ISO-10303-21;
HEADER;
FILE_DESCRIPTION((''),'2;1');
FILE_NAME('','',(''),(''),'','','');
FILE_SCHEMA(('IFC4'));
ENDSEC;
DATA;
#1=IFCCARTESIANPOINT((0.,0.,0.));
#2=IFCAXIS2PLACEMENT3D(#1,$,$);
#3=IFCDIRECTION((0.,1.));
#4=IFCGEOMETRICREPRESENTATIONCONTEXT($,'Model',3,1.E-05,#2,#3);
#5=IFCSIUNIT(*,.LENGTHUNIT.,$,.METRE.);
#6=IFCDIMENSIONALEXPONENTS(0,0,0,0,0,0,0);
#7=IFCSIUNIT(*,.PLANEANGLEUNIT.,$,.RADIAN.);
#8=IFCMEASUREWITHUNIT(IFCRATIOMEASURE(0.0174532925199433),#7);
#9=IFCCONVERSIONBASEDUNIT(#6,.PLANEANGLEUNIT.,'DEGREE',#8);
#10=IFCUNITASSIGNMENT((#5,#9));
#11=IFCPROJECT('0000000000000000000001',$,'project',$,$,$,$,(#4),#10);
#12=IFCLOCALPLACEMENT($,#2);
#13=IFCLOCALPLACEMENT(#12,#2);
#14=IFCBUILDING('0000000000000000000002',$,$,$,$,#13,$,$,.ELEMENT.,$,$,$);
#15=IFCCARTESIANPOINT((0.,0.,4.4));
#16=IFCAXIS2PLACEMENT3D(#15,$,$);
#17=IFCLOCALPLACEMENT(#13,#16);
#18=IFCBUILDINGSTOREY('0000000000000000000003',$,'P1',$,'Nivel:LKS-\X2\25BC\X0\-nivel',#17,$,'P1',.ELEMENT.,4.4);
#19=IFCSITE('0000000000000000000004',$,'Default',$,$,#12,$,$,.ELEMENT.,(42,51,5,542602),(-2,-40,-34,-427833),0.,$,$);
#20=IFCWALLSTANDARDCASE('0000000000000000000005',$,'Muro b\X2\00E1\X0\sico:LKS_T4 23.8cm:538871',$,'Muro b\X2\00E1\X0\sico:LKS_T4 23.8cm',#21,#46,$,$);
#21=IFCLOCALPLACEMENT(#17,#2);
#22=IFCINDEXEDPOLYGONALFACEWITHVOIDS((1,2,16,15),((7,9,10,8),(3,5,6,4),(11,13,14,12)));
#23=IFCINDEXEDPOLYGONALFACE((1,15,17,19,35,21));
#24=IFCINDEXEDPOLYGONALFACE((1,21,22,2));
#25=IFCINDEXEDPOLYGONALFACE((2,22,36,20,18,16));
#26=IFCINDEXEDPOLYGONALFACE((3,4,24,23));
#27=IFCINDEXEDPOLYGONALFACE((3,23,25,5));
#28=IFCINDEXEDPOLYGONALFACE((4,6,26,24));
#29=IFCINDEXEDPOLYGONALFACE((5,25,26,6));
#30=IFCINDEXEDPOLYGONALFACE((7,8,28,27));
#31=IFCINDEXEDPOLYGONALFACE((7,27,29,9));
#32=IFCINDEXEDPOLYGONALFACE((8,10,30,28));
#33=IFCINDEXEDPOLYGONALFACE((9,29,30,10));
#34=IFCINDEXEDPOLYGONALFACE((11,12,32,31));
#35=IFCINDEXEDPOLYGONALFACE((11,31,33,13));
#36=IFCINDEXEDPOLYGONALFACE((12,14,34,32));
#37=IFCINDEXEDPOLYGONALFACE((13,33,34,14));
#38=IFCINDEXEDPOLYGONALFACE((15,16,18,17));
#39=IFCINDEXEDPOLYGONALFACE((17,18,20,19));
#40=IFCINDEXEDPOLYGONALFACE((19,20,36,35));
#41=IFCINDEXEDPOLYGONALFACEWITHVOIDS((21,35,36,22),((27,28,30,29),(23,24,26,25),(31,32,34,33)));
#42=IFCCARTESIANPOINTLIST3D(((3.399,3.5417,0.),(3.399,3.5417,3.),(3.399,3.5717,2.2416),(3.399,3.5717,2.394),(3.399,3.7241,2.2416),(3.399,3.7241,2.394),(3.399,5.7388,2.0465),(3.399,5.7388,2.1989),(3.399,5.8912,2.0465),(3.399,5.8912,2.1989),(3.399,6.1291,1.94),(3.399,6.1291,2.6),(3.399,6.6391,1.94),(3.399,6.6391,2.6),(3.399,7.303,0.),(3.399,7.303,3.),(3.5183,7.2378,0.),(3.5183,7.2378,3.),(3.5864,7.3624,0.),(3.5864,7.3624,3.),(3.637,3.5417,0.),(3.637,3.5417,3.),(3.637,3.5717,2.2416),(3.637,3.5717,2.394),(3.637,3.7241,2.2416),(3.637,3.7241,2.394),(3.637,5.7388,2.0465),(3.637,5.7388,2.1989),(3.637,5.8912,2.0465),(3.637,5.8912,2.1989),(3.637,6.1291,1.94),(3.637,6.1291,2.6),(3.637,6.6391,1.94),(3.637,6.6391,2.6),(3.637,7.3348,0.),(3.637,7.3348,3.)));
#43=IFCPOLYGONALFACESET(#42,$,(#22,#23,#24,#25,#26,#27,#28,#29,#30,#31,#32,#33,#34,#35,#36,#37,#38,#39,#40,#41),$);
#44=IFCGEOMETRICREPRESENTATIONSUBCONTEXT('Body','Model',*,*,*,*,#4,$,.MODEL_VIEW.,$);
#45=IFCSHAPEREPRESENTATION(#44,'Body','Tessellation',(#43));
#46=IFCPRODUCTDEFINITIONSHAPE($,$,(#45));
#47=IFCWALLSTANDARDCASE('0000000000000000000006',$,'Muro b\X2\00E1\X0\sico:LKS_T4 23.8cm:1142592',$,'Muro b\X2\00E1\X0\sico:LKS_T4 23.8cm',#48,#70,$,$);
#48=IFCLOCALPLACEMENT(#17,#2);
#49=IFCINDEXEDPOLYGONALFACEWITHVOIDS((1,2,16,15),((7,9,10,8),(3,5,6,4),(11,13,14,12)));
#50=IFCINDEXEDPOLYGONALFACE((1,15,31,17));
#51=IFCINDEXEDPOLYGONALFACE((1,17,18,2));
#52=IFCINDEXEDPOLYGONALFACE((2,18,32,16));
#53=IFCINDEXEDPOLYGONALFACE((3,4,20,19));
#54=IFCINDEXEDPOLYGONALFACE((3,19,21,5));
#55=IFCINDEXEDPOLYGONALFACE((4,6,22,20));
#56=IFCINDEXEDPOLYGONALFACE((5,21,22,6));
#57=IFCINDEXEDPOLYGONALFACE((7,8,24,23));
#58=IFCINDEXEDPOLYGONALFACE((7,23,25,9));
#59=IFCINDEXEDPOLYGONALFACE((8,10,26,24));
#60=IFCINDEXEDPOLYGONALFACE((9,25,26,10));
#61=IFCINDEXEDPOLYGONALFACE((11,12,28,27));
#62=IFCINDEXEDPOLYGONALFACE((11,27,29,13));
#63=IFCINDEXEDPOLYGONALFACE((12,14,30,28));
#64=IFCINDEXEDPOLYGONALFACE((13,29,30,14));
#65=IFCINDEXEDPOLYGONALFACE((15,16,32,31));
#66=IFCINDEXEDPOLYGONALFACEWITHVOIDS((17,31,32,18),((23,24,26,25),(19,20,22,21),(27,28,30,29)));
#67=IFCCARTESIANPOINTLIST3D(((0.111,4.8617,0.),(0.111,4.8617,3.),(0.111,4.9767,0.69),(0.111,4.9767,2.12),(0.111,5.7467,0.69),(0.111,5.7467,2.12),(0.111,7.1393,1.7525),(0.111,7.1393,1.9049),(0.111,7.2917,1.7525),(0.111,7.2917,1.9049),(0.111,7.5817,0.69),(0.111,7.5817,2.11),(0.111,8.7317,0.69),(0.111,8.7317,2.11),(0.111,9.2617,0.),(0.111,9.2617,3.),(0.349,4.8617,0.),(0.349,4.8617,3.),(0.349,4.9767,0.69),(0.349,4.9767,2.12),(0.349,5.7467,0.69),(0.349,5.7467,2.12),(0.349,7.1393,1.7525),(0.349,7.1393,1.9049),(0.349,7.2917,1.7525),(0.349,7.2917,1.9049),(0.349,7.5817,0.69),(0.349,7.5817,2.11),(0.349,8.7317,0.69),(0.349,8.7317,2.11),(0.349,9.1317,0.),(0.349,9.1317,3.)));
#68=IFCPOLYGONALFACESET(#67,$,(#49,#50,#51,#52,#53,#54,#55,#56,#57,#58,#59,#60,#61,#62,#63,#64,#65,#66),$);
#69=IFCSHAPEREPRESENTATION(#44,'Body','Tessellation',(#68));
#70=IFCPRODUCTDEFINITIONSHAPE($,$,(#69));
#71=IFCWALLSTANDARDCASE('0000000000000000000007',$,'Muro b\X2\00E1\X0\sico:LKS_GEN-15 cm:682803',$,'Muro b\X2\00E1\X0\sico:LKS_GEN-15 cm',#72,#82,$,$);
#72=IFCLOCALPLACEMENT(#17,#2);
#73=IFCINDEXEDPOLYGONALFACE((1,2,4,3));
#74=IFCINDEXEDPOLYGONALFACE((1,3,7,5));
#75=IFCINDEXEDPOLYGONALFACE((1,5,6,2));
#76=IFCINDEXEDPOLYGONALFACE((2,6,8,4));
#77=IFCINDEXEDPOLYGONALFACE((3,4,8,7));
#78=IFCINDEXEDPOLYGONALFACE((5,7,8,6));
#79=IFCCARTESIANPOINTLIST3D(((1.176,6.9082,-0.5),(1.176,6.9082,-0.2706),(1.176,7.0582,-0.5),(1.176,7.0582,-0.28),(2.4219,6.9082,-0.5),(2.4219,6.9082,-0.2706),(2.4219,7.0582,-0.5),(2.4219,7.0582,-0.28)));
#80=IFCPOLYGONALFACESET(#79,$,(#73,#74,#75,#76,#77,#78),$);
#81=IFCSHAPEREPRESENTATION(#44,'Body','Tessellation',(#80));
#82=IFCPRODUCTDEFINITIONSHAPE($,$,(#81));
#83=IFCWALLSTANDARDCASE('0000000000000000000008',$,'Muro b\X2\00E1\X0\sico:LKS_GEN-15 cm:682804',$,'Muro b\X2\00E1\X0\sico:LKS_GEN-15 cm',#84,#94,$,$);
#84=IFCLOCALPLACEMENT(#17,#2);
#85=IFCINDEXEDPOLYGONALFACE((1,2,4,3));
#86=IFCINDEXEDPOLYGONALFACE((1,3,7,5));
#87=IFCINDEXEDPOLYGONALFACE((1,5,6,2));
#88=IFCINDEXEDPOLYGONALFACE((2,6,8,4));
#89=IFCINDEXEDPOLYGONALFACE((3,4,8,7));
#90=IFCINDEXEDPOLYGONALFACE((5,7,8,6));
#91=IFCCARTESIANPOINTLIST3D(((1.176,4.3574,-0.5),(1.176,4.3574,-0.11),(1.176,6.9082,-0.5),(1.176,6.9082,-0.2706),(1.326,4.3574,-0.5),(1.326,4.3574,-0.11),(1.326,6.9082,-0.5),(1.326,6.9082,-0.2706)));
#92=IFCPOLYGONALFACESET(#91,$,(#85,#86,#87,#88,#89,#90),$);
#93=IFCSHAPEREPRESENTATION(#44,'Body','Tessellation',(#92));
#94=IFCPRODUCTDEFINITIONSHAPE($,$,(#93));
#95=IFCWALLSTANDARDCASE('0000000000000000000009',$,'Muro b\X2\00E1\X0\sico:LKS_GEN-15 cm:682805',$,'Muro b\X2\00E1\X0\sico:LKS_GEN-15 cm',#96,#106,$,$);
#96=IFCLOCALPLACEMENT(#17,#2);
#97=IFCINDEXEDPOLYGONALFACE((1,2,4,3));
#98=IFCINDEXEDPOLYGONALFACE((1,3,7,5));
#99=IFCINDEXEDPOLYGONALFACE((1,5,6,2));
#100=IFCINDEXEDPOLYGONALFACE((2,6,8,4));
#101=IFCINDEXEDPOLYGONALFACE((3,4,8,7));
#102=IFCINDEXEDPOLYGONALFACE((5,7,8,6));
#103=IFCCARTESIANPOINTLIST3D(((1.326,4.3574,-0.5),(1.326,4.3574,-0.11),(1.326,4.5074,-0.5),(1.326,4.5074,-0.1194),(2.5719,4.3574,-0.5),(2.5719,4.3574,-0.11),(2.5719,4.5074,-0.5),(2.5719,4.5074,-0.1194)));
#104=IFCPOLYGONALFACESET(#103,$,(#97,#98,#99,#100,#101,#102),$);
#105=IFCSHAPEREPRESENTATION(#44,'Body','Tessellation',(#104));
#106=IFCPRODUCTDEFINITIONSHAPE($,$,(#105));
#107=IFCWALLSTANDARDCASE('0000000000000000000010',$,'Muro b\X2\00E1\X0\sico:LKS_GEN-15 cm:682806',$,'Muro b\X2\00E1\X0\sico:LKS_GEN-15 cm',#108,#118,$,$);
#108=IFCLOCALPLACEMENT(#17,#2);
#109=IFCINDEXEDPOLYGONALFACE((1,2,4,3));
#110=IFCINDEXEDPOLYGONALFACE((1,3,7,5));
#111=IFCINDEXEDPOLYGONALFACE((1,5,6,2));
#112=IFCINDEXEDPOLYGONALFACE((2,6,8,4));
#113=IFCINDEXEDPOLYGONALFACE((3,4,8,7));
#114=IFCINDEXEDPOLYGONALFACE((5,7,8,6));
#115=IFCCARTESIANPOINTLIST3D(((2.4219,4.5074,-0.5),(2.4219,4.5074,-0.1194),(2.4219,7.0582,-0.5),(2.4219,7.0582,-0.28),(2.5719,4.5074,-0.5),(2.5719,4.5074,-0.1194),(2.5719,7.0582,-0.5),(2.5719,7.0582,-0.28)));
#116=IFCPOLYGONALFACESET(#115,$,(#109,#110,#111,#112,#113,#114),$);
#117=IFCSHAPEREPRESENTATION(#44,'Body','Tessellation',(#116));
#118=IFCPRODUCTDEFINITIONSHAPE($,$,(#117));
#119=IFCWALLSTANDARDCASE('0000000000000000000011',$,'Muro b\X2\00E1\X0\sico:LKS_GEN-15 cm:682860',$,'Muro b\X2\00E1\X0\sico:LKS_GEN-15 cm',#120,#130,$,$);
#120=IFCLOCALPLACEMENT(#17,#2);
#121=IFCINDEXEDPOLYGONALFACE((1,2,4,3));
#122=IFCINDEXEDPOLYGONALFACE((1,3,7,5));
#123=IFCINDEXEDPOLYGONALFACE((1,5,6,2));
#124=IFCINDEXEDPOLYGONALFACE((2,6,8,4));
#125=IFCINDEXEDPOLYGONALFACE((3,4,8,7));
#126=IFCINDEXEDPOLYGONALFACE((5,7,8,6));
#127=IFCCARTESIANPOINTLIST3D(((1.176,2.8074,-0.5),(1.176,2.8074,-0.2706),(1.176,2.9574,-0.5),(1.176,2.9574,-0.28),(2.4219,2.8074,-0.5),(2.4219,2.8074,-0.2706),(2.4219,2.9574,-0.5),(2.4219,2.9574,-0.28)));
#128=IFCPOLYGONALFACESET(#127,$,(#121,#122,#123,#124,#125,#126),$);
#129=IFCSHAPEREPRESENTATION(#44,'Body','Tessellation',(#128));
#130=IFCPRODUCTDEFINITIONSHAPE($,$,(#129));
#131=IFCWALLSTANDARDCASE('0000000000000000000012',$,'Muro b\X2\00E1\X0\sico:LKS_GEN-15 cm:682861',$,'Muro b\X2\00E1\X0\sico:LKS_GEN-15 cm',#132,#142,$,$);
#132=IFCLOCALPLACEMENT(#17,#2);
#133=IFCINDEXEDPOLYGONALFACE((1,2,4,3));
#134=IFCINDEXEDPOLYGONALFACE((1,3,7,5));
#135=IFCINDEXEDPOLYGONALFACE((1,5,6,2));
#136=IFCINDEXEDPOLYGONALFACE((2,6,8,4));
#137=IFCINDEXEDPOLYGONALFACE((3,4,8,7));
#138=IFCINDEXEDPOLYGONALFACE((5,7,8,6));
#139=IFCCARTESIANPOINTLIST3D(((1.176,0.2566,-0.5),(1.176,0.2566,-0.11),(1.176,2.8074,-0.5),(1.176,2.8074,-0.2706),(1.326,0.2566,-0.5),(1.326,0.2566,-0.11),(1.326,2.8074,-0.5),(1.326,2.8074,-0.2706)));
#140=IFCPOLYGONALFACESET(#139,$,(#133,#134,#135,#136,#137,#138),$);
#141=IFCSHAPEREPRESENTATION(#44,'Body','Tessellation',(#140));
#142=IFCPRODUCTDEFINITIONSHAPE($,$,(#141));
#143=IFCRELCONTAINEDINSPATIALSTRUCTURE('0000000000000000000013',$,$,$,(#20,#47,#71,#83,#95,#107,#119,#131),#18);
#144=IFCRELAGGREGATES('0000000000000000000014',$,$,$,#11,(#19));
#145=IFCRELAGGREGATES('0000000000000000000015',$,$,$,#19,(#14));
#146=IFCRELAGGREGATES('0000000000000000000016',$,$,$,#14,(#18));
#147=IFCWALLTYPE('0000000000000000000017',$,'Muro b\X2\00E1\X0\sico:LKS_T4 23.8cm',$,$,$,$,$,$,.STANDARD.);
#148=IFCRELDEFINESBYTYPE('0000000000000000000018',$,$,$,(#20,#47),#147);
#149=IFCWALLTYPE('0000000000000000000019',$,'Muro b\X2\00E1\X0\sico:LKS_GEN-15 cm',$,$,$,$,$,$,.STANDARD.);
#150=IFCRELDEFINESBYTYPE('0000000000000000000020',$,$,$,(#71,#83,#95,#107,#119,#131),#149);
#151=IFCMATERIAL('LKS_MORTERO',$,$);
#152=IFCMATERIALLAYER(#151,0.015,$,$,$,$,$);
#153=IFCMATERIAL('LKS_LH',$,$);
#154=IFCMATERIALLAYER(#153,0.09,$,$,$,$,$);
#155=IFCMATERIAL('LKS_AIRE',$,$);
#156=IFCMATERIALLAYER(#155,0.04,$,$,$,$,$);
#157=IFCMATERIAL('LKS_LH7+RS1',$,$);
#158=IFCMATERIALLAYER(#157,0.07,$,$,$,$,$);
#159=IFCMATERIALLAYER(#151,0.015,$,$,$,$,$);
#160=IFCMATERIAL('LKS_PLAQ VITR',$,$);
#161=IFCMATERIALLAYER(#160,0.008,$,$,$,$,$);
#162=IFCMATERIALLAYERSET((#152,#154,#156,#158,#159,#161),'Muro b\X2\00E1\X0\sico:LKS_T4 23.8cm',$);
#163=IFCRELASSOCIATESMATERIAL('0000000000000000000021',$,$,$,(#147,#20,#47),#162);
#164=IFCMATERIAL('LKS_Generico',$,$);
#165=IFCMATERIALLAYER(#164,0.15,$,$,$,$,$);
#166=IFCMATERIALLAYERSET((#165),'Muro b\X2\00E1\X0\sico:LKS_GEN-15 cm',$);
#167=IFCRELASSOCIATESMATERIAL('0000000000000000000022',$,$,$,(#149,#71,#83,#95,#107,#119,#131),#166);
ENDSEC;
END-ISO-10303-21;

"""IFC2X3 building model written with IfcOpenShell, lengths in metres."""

from ifc_helpers import new_model, entity, si_unit, converted_unit, direction, frame, frame_2d, origin, place, context, subcontext, project, spatial, polyline, rectangle, outline, extrude, clip, bounded_halfspace, material, layer, layer_set, layer_usage, type_object, element, save


model = new_model("IFC2X3")

# Units and contexts
model_context = context("Model", 3, precision=1e-05, world=origin(), true_north=direction((0.0, 1.0)))
body_context = subcontext(model_context, "Body", "Model", "MODEL_VIEW")
ifc_project = project(units=[si_unit("LENGTHUNIT", "METRE"), converted_unit("PLANEANGLEUNIT", "DEGREE", entity("IfcRatioMeasure", 0.0174532925199433), si_unit("PLANEANGLEUNIT", "RADIAN"), dimensions=[0, 0, 0, 0, 0, 0, 0])], contexts=[model_context])

# Site, building, storey
site_placement = place(None, origin())
site = spatial("IfcSite", under=ifc_project, at=site_placement, Name="Default", CompositionType="ELEMENT", RefLatitude=(42, 51, 5, 542602), RefLongitude=(-2, -40, -34, -427833), RefElevation=0.0)
building_placement = place(site_placement, origin())
building = spatial("IfcBuilding", under=site, at=building_placement, CompositionType="ELEMENT")
storey_placement = place(building_placement, frame((0.0, 0.0, 4.4)))
storey = spatial("IfcBuildingStorey", under=building, at=storey_placement, Name="P1", ObjectType="Nivel:LKS-▼-nivel", LongName="P1", CompositionType="ELEMENT", Elevation=4.4)

# Shared definitions
ifc_material_1 = material(Name="LKS_Generico")

# Shared definitions
ifc_material_2 = material(Name="LKS_MORTERO")
ifc_material_3 = material(Name="LKS_PLAQ VITR")

# Shared definitions
ifc_material_4 = material(Name="LKS_LH")
ifc_material_5 = material(Name="LKS_AIRE")
ifc_material_6 = material(Name="LKS_LH7+RS1")

# Walls, openings
ifc_layer_1 = layer(ifc_material_2, 0.015)
ifc_layer_2 = layer(ifc_material_4, 0.09)
ifc_layer_3 = layer(ifc_material_5, 0.04)
ifc_layer_4 = layer(ifc_material_6, 0.07)
ifc_layer_5 = layer(ifc_material_2, 0.015)
ifc_layer_6 = layer(ifc_material_3, 0.008)
ifc_layer_set_1 = layer_set([ifc_layer_1, ifc_layer_2, ifc_layer_3, ifc_layer_4, ifc_layer_5, ifc_layer_6], Name="Muro básico:LKS_T4 23.8cm")
ifc_layer_usage_1 = layer_usage(ifc_layer_set_1, "AXIS2", "POSITIVE", -0.119)
wall_type_1 = type_object("IfcWallType", Name="Muro básico:LKS_T4 23.8cm", PredefinedType="STANDARD", material=ifc_layer_set_1)
wall_1_placement = place(storey_placement, frame((3.518, 7.3348, 0.0), z_axis=(0.0, 0.0, 1.0), x_axis=(0.0, -1.0, 0.0)))
wall_1 = element("IfcWallStandardCase", 1, at=wall_1_placement, inside=storey, type_object=wall_type_1, material=ifc_layer_usage_1, Name="Muro básico:LKS_T4 23.8cm:538871", ObjectType="Muro básico:LKS_T4 23.8cm", context=body_context, shape_type="Clipping", body=[
    clip(clip(extrude(outline(polyline([(0.0, 0.119), (-0.0276, 0.0685), (0.097, 0.0004), (0.0318, -0.119), (3.793, -0.119), (3.793, 0.111), (3.793, 0.119), (1.706, 0.119), (1.606, 0.119), (0.0, 0.119)])), origin(), (0.0, 0.0, 1.0), 3.0), bounded_halfspace(frame((0.097, 0.0004, 0.0), z_axis=(0.479561, 0.877509, 0.0), x_axis=(0.0, 0.0, -1.0)), True, frame((0.097, 0.0004, 0.0), z_axis=(0.479561, 0.877509, 0.0), x_axis=(0.0, 0.0, -1.0)), polyline([(0.0, 0.0), (0.0, 0.142), (-3.0, 0.142), (-3.0, 0.0), (-2.67, 0.0), (0.0, 0.0)]))), bounded_halfspace(frame((0.097, 0.0004, 3.0), z_axis=(0.877509, -0.479561, 0.0), x_axis=(0.0, 0.0, -1.0)), True, frame((0.097, 0.0004, 3.0), z_axis=(0.877509, -0.479561, 0.0), x_axis=(0.0, 0.0, -1.0)), polyline([(0.0, 0.0), (0.0, -0.0802), (0.0, -0.1361), (3.0, -0.1361), (3.0, 0.0), (0.33, 0.0), (0.0, 0.0)]))),
])
opening_1_placement = place(wall_1_placement, origin())
element("IfcOpeningElement", 2, at=opening_1_placement, cuts=wall_1, ObjectType="Opening", context=body_context, shape_type="SweptSolid", body=[
    extrude(rectangle(XDim=0.1524, YDim=0.1524, at=frame_2d((0.0, 0.0), x_axis=(0.0, 1.0))), frame((3.6868, -1.405, 2.3178), z_axis=(0.0, 1.0, 0.0), x_axis=(-1.0, 0.0, 0.0)), (0.0, 0.0, 1.0), 3.048),
])
opening_2_placement = place(wall_1_placement, origin())
element("IfcOpeningElement", 3, at=opening_2_placement, cuts=wall_1, ObjectType="Opening", context=body_context, shape_type="SweptSolid", body=[
    extrude(rectangle(XDim=0.1524, YDim=0.1524, at=frame_2d((0.0, 0.0), x_axis=(0.0, 1.0))), frame((1.5198, -1.405, 2.1227), z_axis=(0.0, 1.0, 0.0), x_axis=(-1.0, 0.0, 0.0)), (0.0, 0.0, 1.0), 3.048),
])
opening_3_placement = place(wall_1_placement, frame((1.2057, 0.119, 1.94)))
element("IfcOpeningElement", 4, at=opening_3_placement, cuts=wall_1, ObjectType="Opening", context=body_context, shape_type="SweptSolid", body=[
    extrude(rectangle(XDim=0.66, YDim=0.51, at=frame_2d((0.33, 0.255), x_axis=(1.0, 0.0))), frame((0.0, 0.0, 0.0), z_axis=(0.0, -1.0, 0.0), x_axis=(0.0, 0.0, 1.0)), (0.0, 0.0, 1.0), 0.238),
])
ifc_layer_usage_2 = layer_usage(ifc_layer_set_1, "AXIS2", "POSITIVE", -0.119)
wall_2_placement = place(storey_placement, frame((0.23, 4.8617, 0.0), z_axis=(0.0, 0.0, 1.0), x_axis=(0.0, 1.0, 0.0)))
wall_2 = element("IfcWallStandardCase", 5, at=wall_2_placement, inside=storey, type_object=wall_type_1, material=ifc_layer_usage_2, Name="Muro básico:LKS_T4 23.8cm:1142592", ObjectType="Muro básico:LKS_T4 23.8cm", context=body_context, shape_type="SweptSolid", body=[
    extrude(outline(polyline([(4.2699, -0.119), (4.4, 0.119), (1.8, 0.119), (1.7, 0.119), (0.0, 0.119), (0.0, 0.111), (0.0, -0.119), (4.2699, -0.119)])), origin(), (0.0, 0.0, 1.0), 3.0),
])
opening_4_placement = place(wall_2_placement, origin())
element("IfcOpeningElement", 6, at=opening_4_placement, cuts=wall_2, ObjectType="Opening", context=body_context, shape_type="SweptSolid", body=[
    extrude(rectangle(XDim=0.1524, YDim=0.1524, at=frame_2d((0.0, 0.0), x_axis=(0.0, 1.0))), frame((2.3538, -1.405, 1.8287), z_axis=(0.0, 1.0, 0.0), x_axis=(-1.0, 0.0, 0.0)), (0.0, 0.0, 1.0), 3.048),
])
opening_5_placement = place(wall_2_placement, frame((3.87, 0.119, 0.69)))
element("IfcOpeningElement", 7, at=opening_5_placement, cuts=wall_2, ObjectType="Opening", context=body_context, shape_type="SweptSolid", body=[
    extrude(rectangle(XDim=1.42, YDim=1.15, at=frame_2d((0.71, 0.575), x_axis=(1.0, 0.0))), frame((0.0, 0.0, 0.0), z_axis=(0.0, -1.0, 0.0), x_axis=(0.0, 0.0, 1.0)), (0.0, 0.0, 1.0), 0.238),
])
opening_6_placement = place(wall_2_placement, frame((0.885, 0.119, 0.69)))
element("IfcOpeningElement", 8, at=opening_6_placement, cuts=wall_2, ObjectType="Opening", context=body_context, shape_type="SweptSolid", body=[
    extrude(rectangle(XDim=1.43, YDim=0.77, at=frame_2d((0.715, 0.385), x_axis=(1.0, 0.0))), frame((0.0, 0.0, 0.0), z_axis=(0.0, -1.0, 0.0), x_axis=(0.0, 0.0, 1.0)), (0.0, 0.0, 1.0), 0.238),
])

# Walls
ifc_layer_7 = layer(ifc_material_1, 0.15)
ifc_layer_set_2 = layer_set([ifc_layer_7], Name="Muro básico:LKS_GEN-15 cm")
ifc_layer_usage_3 = layer_usage(ifc_layer_set_2, "AXIS2", "NEGATIVE", 0.075)
wall_type_2 = type_object("IfcWallType", Name="Muro básico:LKS_GEN-15 cm", PredefinedType="STANDARD", material=ifc_layer_set_2)
wall_3_placement = place(storey_placement, frame((1.176, 6.9832, -0.5)))
element("IfcWallStandardCase", 9, at=wall_3_placement, inside=storey, type_object=wall_type_2, material=ifc_layer_usage_3, Name="Muro básico:LKS_GEN-15 cm:682803", ObjectType="Muro básico:LKS_GEN-15 cm", context=body_context, shape_type="Clipping", body=[
    clip(extrude(rectangle(XDim=1.2459, YDim=0.15, at=frame_2d((0.6229, 0.0), x_axis=(-1.0, 0.0))), origin(), (0.0, 0.0, 1.0), 0.2294), bounded_halfspace(frame((0.0, -0.075, 0.2294), z_axis=(0.0, 0.06282, 0.998025), x_axis=(0.0, 0.998025, -0.06282)), False, frame((0.0, -0.075, 0.2294)), polyline([(0.0, 0.0), (0.15, 0.0), (1.2459, 0.0), (1.2459, 0.15), (0.0, 0.15), (0.0, 0.0)]))),
])
ifc_layer_usage_4 = layer_usage(ifc_layer_set_2, "AXIS2", "NEGATIVE", 0.075)
wall_4_placement = place(storey_placement, frame((1.251, 4.3574, -0.5), z_axis=(0.0, 0.0, 1.0), x_axis=(0.0, 1.0, 0.0)))
element("IfcWallStandardCase", 10, at=wall_4_placement, inside=storey, type_object=wall_type_2, material=ifc_layer_usage_4, Name="Muro básico:LKS_GEN-15 cm:682804", ObjectType="Muro básico:LKS_GEN-15 cm", context=body_context, shape_type="Clipping", body=[
    clip(extrude(rectangle(XDim=2.5508, YDim=0.15, at=frame_2d((1.2754, 0.0), x_axis=(-1.0, 0.0))), origin(), (0.0, 0.0, 1.0), 0.39), bounded_halfspace(frame((0.0, -0.075, 0.39), z_axis=(0.06282, 0.0, 0.998025), x_axis=(0.998025, 0.0, -0.06282)), False, frame((0.0, -0.075, 0.39)), polyline([(0.0, 0.0), (0.15, 0.0), (2.5508, 0.0), (2.5508, 0.15), (0.0, 0.15), (0.0, 0.0)]))),
])
ifc_layer_usage_5 = layer_usage(ifc_layer_set_2, "AXIS2", "NEGATIVE", 0.075)
wall_5_placement = place(storey_placement, frame((2.5719, 4.4324, -0.5), z_axis=(0.0, 0.0, 1.0), x_axis=(-1.0, 0.0, 0.0)))
element("IfcWallStandardCase", 11, at=wall_5_placement, inside=storey, type_object=wall_type_2, material=ifc_layer_usage_5, Name="Muro básico:LKS_GEN-15 cm:682805", ObjectType="Muro básico:LKS_GEN-15 cm", context=body_context, shape_type="Clipping", body=[
    clip(extrude(rectangle(XDim=1.2459, YDim=0.15, at=frame_2d((0.6229, 0.0), x_axis=(-1.0, 0.0))), origin(), (0.0, 0.0, 1.0), 0.39), bounded_halfspace(frame((0.0, -0.075, 0.3806), z_axis=(0.0, -0.06282, 0.998025), x_axis=(0.0, -0.998025, -0.06282)), False, frame((0.0, -0.075, 0.3806)), polyline([(0.0, 0.0), (0.15, 0.0), (1.2459, 0.0), (1.2459, 0.15), (0.0, 0.15), (0.0, 0.0)]))),
])
ifc_layer_usage_6 = layer_usage(ifc_layer_set_2, "AXIS2", "NEGATIVE", 0.075)
wall_6_placement = place(storey_placement, frame((2.4969, 7.0582, -0.5), z_axis=(0.0, 0.0, 1.0), x_axis=(0.0, -1.0, 0.0)))
element("IfcWallStandardCase", 12, at=wall_6_placement, inside=storey, type_object=wall_type_2, material=ifc_layer_usage_6, Name="Muro básico:LKS_GEN-15 cm:682806", ObjectType="Muro básico:LKS_GEN-15 cm", context=body_context, shape_type="Clipping", body=[
    clip(extrude(rectangle(XDim=2.5508, YDim=0.15, at=frame_2d((1.2754, 0.0), x_axis=(-1.0, 0.0))), origin(), (0.0, 0.0, 1.0), 0.3806), bounded_halfspace(frame((0.0, -0.075, 0.22), z_axis=(-0.06282, 0.0, 0.998025), x_axis=(-0.998025, 0.0, -0.06282)), False, frame((0.0, -0.075, 0.22)), polyline([(0.0, 0.0), (0.15, 0.0), (2.5508, 0.0), (2.5508, 0.15), (0.0, 0.15), (0.0, 0.0)]))),
])
ifc_layer_usage_7 = layer_usage(ifc_layer_set_2, "AXIS2", "NEGATIVE", 0.075)
wall_7_placement = place(storey_placement, frame((1.176, 2.8824, -0.5)))
element("IfcWallStandardCase", 13, at=wall_7_placement, inside=storey, type_object=wall_type_2, material=ifc_layer_usage_7, Name="Muro básico:LKS_GEN-15 cm:682860", ObjectType="Muro básico:LKS_GEN-15 cm", context=body_context, shape_type="Clipping", body=[
    clip(extrude(rectangle(XDim=1.2459, YDim=0.15, at=frame_2d((0.6229, 0.0), x_axis=(-1.0, 0.0))), origin(), (0.0, 0.0, 1.0), 0.2294), bounded_halfspace(frame((0.0, -0.075, 0.2294), z_axis=(0.0, 0.06282, 0.998025), x_axis=(0.0, 0.998025, -0.06282)), False, frame((0.0, -0.075, 0.2294)), polyline([(0.0, 0.0), (0.15, 0.0), (1.2459, 0.0), (1.2459, 0.15), (0.0, 0.15), (0.0, 0.0)]))),
])
ifc_layer_usage_8 = layer_usage(ifc_layer_set_2, "AXIS2", "NEGATIVE", 0.075)
wall_8_placement = place(storey_placement, frame((1.251, 0.2566, -0.5), z_axis=(0.0, 0.0, 1.0), x_axis=(0.0, 1.0, 0.0)))
element("IfcWallStandardCase", 14, at=wall_8_placement, inside=storey, type_object=wall_type_2, material=ifc_layer_usage_8, Name="Muro básico:LKS_GEN-15 cm:682861", ObjectType="Muro básico:LKS_GEN-15 cm", context=body_context, shape_type="Clipping", body=[
    clip(extrude(rectangle(XDim=2.5508, YDim=0.15, at=frame_2d((1.2754, 0.0), x_axis=(-1.0, 0.0))), origin(), (0.0, 0.0, 1.0), 0.39), bounded_halfspace(frame((0.0, -0.075, 0.39), z_axis=(0.06282, 0.0, 0.998025), x_axis=(0.998025, 0.0, -0.06282)), False, frame((0.0, -0.075, 0.39)), polyline([(0.0, 0.0), (0.15, 0.0), (2.5508, 0.0), (2.5508, 0.15), (0.0, 0.15), (0.0, 0.0)]))),
])

save(model, "model.ifc")
